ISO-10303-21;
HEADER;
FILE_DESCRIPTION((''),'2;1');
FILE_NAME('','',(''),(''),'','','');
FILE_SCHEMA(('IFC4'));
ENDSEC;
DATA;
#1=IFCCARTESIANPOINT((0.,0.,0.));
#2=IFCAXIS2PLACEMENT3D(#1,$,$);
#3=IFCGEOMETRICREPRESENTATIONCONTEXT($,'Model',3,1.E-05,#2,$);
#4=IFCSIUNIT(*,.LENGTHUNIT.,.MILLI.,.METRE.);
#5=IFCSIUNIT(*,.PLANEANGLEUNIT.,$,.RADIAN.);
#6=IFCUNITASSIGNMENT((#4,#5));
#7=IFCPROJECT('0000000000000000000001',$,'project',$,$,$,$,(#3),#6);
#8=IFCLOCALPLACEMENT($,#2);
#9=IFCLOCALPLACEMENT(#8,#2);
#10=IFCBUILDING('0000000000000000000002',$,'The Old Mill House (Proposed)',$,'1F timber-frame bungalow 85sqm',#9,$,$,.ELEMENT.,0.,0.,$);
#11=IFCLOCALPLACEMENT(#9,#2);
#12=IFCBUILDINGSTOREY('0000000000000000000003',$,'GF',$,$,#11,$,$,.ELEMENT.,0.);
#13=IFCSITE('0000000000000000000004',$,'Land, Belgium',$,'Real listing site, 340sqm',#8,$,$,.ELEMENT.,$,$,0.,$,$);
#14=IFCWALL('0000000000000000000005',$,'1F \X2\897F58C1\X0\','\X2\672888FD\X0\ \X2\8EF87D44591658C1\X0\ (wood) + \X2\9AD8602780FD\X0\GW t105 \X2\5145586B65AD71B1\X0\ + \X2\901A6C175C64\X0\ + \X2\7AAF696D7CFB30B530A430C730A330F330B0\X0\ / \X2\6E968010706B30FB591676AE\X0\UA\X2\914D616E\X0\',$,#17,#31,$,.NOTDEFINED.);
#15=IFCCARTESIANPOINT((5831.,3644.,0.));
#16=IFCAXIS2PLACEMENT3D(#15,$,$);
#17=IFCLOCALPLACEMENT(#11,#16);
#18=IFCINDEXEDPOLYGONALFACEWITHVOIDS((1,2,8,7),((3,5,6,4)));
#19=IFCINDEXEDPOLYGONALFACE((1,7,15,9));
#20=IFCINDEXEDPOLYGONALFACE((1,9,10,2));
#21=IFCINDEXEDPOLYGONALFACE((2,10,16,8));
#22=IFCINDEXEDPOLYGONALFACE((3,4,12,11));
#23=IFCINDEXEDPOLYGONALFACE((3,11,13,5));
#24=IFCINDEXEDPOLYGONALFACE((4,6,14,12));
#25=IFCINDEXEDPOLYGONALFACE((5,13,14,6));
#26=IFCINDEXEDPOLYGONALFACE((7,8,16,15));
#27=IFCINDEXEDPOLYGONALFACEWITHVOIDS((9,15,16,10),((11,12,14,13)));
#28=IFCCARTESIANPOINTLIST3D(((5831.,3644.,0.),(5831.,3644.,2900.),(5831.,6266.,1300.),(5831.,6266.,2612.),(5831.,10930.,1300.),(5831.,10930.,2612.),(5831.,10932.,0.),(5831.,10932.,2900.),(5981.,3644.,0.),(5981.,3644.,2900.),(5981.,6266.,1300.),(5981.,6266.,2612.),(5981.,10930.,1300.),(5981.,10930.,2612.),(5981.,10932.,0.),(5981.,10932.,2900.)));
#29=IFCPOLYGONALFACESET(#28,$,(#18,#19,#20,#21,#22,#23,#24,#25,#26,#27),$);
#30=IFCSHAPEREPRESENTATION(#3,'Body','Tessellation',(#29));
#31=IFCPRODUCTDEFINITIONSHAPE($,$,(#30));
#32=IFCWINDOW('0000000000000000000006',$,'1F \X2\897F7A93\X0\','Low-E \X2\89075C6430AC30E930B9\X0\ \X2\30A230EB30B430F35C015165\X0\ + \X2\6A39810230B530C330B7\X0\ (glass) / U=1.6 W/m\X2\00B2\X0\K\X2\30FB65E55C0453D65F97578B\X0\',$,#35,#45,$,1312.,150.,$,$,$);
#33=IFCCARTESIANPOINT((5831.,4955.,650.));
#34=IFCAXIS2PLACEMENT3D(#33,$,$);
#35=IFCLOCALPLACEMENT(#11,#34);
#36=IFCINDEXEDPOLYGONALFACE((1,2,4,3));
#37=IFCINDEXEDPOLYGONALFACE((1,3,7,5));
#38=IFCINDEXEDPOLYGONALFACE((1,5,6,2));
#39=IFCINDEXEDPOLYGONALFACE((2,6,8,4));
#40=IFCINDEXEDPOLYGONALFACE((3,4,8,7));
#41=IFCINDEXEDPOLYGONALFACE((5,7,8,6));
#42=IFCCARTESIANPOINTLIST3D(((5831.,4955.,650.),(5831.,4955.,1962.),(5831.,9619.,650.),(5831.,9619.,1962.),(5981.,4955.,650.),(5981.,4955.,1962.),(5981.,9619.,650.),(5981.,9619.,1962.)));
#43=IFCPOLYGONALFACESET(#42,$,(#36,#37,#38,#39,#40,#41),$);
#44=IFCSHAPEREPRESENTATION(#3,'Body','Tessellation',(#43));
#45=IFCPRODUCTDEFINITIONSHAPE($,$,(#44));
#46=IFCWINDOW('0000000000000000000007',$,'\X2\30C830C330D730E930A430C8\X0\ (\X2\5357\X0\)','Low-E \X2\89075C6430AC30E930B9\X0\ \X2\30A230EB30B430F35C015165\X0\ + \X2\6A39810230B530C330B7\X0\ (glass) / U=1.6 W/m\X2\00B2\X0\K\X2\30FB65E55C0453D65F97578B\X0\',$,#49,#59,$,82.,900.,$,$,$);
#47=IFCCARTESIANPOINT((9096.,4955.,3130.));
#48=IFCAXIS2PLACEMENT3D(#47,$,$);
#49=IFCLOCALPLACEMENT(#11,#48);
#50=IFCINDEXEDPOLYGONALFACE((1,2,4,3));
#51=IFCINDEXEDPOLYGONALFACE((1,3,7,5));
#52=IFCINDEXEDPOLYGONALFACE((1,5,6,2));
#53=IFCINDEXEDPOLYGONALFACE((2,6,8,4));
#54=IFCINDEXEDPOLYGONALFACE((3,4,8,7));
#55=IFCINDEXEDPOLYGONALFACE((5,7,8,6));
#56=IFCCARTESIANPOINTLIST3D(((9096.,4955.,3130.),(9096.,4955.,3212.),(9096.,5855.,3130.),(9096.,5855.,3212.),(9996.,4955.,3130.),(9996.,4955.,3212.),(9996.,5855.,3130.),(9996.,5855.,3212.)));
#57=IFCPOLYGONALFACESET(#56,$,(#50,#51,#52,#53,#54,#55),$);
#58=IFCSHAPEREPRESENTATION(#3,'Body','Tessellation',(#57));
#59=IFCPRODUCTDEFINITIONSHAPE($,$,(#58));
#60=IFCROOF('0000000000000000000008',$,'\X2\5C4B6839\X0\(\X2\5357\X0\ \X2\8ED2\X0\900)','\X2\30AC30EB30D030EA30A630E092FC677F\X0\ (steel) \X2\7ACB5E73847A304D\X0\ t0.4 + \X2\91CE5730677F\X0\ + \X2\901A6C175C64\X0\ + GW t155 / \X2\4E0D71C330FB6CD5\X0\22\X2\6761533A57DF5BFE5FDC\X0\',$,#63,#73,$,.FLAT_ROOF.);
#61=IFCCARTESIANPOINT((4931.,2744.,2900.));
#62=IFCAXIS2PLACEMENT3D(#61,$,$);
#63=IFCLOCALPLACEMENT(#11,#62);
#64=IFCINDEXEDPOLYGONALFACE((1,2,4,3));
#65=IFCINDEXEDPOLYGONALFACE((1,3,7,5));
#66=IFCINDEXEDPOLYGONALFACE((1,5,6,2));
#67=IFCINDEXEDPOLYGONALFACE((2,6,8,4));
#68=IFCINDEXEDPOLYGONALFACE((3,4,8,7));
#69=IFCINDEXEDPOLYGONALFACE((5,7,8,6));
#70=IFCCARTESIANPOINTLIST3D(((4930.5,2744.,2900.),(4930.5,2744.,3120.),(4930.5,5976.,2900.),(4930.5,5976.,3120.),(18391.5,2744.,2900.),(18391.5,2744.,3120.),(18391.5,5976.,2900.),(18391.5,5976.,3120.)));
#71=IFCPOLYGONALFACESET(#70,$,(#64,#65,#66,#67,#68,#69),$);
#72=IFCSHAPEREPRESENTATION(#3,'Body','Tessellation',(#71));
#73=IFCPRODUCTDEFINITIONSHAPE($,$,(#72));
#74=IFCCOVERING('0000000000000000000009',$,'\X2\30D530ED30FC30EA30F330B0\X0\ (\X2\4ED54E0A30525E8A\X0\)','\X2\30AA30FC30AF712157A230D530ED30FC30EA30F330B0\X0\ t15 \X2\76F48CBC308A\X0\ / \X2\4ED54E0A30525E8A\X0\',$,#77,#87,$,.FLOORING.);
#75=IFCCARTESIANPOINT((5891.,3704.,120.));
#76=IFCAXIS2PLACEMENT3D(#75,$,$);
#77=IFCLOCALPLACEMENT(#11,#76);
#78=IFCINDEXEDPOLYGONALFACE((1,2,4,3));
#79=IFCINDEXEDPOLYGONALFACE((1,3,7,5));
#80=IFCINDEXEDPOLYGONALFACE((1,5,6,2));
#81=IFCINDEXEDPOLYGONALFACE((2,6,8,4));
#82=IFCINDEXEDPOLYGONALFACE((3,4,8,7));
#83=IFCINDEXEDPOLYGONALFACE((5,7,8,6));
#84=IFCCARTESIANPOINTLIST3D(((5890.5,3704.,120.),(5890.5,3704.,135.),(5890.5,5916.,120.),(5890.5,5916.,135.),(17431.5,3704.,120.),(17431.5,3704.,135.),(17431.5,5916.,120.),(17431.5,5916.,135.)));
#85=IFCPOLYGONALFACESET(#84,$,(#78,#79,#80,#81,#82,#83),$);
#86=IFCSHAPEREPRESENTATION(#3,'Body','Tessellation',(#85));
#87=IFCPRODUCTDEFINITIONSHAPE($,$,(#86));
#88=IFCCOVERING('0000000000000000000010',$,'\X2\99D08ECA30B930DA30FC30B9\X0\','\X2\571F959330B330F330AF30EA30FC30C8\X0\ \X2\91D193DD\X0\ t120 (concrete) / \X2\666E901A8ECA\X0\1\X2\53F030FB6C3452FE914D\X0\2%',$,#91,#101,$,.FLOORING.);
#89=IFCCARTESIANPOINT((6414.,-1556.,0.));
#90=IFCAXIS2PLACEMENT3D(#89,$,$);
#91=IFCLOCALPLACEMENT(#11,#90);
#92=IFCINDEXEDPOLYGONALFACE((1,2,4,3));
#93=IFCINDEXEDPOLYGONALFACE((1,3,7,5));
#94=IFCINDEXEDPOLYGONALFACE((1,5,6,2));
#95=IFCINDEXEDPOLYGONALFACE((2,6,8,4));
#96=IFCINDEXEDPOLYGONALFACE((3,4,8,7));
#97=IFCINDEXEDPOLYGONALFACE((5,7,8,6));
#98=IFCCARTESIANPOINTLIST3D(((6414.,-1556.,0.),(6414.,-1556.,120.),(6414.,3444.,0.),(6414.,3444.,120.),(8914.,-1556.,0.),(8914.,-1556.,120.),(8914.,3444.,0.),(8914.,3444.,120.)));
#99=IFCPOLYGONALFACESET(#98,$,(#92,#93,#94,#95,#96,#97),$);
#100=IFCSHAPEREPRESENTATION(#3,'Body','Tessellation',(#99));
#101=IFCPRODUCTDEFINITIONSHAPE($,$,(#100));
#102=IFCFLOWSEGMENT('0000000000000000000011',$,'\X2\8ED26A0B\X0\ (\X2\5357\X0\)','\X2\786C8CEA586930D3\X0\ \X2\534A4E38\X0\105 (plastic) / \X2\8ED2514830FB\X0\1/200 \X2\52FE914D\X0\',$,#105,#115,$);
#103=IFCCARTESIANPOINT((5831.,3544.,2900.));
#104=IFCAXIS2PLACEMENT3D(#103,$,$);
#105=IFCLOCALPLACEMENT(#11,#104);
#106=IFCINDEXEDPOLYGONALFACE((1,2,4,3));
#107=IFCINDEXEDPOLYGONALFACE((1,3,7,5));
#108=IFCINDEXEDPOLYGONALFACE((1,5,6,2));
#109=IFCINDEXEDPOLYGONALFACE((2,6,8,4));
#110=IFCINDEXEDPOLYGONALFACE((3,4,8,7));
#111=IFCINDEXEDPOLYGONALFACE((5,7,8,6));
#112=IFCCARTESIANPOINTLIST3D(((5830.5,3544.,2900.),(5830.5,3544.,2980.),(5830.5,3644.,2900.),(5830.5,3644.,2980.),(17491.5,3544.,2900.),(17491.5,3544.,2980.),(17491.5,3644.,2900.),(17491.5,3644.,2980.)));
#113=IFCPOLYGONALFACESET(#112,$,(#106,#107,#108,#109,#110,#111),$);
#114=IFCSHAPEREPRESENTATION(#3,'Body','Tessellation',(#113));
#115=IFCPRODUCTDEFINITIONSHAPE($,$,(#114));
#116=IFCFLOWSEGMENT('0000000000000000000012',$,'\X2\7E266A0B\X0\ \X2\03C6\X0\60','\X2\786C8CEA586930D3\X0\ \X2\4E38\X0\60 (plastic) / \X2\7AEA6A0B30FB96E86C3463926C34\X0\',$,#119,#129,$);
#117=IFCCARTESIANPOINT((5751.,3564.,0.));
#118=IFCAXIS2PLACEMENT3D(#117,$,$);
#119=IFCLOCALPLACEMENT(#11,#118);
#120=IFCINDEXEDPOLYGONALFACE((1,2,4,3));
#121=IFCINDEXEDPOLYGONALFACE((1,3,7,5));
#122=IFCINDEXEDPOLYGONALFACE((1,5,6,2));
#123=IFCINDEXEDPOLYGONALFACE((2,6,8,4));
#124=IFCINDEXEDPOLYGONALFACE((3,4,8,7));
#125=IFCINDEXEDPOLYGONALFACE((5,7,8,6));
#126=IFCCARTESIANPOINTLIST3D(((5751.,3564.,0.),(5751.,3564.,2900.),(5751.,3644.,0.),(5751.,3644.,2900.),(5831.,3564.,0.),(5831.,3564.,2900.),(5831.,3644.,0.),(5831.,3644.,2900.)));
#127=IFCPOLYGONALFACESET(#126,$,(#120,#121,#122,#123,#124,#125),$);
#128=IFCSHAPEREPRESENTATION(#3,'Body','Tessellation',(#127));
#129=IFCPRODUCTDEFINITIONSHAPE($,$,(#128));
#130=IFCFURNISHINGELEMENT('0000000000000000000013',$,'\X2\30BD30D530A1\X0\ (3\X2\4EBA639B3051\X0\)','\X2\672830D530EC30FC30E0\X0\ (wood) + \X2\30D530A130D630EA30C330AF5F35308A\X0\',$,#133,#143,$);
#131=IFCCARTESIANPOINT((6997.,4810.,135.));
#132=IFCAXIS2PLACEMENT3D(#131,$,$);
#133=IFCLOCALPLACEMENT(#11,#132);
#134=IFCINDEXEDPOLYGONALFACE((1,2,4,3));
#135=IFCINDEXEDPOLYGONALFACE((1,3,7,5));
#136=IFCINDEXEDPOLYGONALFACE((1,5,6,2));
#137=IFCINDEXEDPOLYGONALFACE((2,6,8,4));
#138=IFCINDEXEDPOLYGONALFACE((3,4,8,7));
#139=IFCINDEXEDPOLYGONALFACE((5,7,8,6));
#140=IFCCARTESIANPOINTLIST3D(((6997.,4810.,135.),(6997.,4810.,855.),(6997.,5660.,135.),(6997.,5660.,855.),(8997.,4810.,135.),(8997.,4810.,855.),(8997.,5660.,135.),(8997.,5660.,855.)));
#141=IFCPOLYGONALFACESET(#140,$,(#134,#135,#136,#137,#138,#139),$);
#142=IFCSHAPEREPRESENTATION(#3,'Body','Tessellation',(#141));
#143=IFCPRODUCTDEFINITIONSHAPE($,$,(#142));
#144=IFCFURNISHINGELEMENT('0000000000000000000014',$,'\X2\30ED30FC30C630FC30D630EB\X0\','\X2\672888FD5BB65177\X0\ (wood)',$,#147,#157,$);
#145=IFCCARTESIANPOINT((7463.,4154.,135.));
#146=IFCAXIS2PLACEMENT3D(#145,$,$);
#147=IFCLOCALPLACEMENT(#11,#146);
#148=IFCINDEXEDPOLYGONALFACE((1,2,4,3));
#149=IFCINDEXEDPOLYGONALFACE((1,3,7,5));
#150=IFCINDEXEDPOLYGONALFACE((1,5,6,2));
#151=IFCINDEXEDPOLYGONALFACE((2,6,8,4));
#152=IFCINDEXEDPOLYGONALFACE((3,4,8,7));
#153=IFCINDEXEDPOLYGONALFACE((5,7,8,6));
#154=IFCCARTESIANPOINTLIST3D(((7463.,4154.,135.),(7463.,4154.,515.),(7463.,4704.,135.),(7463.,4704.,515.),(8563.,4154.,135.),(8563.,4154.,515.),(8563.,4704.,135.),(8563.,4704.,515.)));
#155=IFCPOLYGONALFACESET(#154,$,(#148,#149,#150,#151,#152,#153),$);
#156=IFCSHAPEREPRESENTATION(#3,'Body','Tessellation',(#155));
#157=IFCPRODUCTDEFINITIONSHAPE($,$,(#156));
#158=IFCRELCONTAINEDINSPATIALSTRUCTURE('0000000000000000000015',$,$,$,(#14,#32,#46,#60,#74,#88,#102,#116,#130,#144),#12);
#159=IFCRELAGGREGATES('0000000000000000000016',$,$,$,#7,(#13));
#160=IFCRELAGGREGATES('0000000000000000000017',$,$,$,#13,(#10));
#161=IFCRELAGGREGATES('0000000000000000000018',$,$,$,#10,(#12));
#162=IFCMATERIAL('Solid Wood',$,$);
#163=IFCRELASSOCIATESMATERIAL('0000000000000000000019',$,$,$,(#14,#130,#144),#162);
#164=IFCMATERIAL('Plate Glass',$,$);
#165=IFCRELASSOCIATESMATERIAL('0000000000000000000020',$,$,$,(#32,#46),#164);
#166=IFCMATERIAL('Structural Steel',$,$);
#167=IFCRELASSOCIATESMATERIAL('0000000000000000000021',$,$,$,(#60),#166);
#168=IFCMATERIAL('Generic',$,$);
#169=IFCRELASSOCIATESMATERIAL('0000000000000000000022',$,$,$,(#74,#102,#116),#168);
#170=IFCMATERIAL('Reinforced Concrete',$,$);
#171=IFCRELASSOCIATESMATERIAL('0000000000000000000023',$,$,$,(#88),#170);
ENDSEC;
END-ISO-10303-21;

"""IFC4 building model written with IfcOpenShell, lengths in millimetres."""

from ifc_helpers import new_model, si_unit, frame, frame_2d, origin, place, context, project, spatial, rectangle, extrude, material, element, fill, save


model = new_model("IFC4")

# Units and contexts
model_context = context("Model", 3, precision=1e-05, world=origin())
ifc_project = project(units=[si_unit("LENGTHUNIT", "METRE", prefix="MILLI"), si_unit("PLANEANGLEUNIT", "RADIAN")], contexts=[model_context])

# Site, building, storey
site_placement = place(None, origin())
site = spatial("IfcSite", under=ifc_project, at=site_placement, Name="Land, Belgium", ObjectType="Real listing site, 340sqm", CompositionType="ELEMENT", RefElevation=0.0)
building_placement = place(site_placement, origin())
building = spatial("IfcBuilding", under=site, at=building_placement, Name="The Old Mill House (Proposed)", ObjectType="1F timber-frame bungalow 85sqm", CompositionType="ELEMENT", ElevationOfRefHeight=0.0, ElevationOfTerrain=0.0)
storey_placement = place(building_placement, origin())
storey = spatial("IfcBuildingStorey", under=building, at=storey_placement, Name="GF", CompositionType="ELEMENT", Elevation=0.0)

# Shared definitions
ifc_material_1 = material(Name="Solid Wood")

# Shared definitions
ifc_material_2 = material(Name="Reinforced Concrete")

# Shared definitions
ifc_material_3 = material(Name="Plate Glass")

# Wall, opening, window
wall_1_placement = place(storey_placement, frame((5831.0, 3644.0, 0.0)))
wall_1 = element("IfcWall", 1, at=wall_1_placement, inside=storey, material=ifc_material_1, Name="1F 西壁", Description="木製 軸組外壁 (wood) + 高性能GW t105 充填断熱 + 通気層 + 窯業系サイディング / 準耐火・外皮UA配慮", PredefinedType="NOTDEFINED", context=model_context, shape_type="SweptSolid", body=[
    extrude(rectangle(XDim=150.0, YDim=7288.0, at=frame_2d((75.0, 3644.0))), frame((5831.0, 3644.0, 0.0)), (0.0, 0.0, 1.0), 2900.0),
])
opening_1_placement = place(storey_placement, frame((5831.0, 4955.0, 650.0)))
opening_1 = element("IfcOpeningElement", 2, at=opening_1_placement, cuts=wall_1, PredefinedType="NOTDEFINED", context=model_context, shape_type="SweptSolid", body=[
    extrude(rectangle(XDim=150.0, YDim=4664.0, at=frame_2d((75.0, 2332.0))), frame((5831.0, 4955.0, 650.0)), (0.0, 0.0, 1.0), 1312.0),
])
window_1_placement = place(storey_placement, frame((5831.0, 4955.0, 650.0)))
window_1 = element("IfcWindow", 3, at=window_1_placement, inside=storey, material=ifc_material_3, Name="1F 西窓", Description="Low-E 複層ガラス アルゴン封入 + 樹脂サッシ (glass) / U=1.6 W/m²K・日射取得型", OverallHeight=1312.0, OverallWidth=150.0, context=model_context, shape_type="SweptSolid", body=[
    extrude(rectangle(XDim=150.0, YDim=4664.0, at=frame_2d((75.0, 2332.0))), frame((5831.0, 4955.0, 650.0)), (0.0, 0.0, 1.0), 1312.0),
])
fill(opening_1, window_1)

# Window
window_2_placement = place(storey_placement, frame((9096.0, 4955.0, 3130.0)))
element("IfcWindow", 4, at=window_2_placement, inside=storey, material=ifc_material_3, Name="トップライト (南)", Description="Low-E 複層ガラス アルゴン封入 + 樹脂サッシ (glass) / U=1.6 W/m²K・日射取得型", OverallHeight=82.0, OverallWidth=900.0, context=model_context, shape_type="SweptSolid", body=[
    extrude(rectangle(XDim=900.0, YDim=900.0, at=frame_2d((450.0, 450.0))), frame((9096.0, 4955.0, 3130.0)), (0.0, 0.0, 1.0), 82.0),
])

# Roof
ifc_material_4 = material(Name="Structural Steel")
roof_1_placement = place(storey_placement, frame((4931.0, 2744.0, 2900.0)))
element("IfcRoof", 5, at=roof_1_placement, inside=storey, material=ifc_material_4, Name="屋根(南 軒900)", Description="ガルバリウム鋼板 (steel) 立平葺き t0.4 + 野地板 + 通気層 + GW t155 / 不燃・法22条区域対応", PredefinedType="FLAT_ROOF", context=model_context, shape_type="SweptSolid", body=[
    extrude(rectangle(XDim=13461.0, YDim=3232.0, at=frame_2d((6730.0, 1616.0))), frame((4931.0, 2744.0, 2900.0)), (0.0, 0.0, 1.0), 220.0),
])

# Coverings
ifc_material_5 = material(Name="Generic")
covering_1_placement = place(storey_placement, frame((5891.0, 3704.0, 120.0)))
element("IfcCovering", 6, at=covering_1_placement, inside=storey, material=ifc_material_5, Name="フローリング (仕上げ床)", Description="オーク無垢フローリング t15 直貼り / 仕上げ床", PredefinedType="FLOORING", context=model_context, shape_type="SweptSolid", body=[
    extrude(rectangle(XDim=11541.0, YDim=2212.0, at=frame_2d((5770.0, 1106.0))), frame((5891.0, 3704.0, 120.0)), (0.0, 0.0, 1.0), 15.0),
])
covering_2_placement = place(storey_placement, frame((6414.0, -1556.0, 0.0)))
element("IfcCovering", 7, at=covering_2_placement, inside=storey, material=ifc_material_2, Name="駐車スペース", Description="土間コンクリート 金鏝 t120 (concrete) / 普通車1台・水勾配2%", PredefinedType="FLOORING", context=model_context, shape_type="SweptSolid", body=[
    extrude(rectangle(XDim=2500.0, YDim=5000.0, at=frame_2d((1250.0, 2500.0))), frame((6414.0, -1556.0, 0.0)), (0.0, 0.0, 1.0), 120.0),
])

# Flow segments
flow_segment_1_placement = place(storey_placement, frame((5831.0, 3544.0, 2900.0)))
element("IfcFlowSegment", 8, at=flow_segment_1_placement, inside=storey, material=ifc_material_5, Name="軒樋 (南)", Description="硬質塩ビ 半丸105 (plastic) / 軒先・1/200 勾配", context=model_context, shape_type="SweptSolid", body=[
    extrude(rectangle(XDim=11661.0, YDim=100.0, at=frame_2d((5830.0, 50.0))), frame((5831.0, 3544.0, 2900.0)), (0.0, 0.0, 1.0), 80.0),
])
flow_segment_2_placement = place(storey_placement, frame((5751.0, 3564.0, 0.0)))
element("IfcFlowSegment", 9, at=flow_segment_2_placement, inside=storey, material=ifc_material_5, Name="縦樋 φ60", Description="硬質塩ビ 丸60 (plastic) / 竪樋・雨水排水", context=model_context, shape_type="SweptSolid", body=[
    extrude(rectangle(XDim=80.0, YDim=80.0, at=frame_2d((40.0, 40.0))), frame((5751.0, 3564.0, 0.0)), (0.0, 0.0, 1.0), 2900.0),
])

# Furnishing elements
furnishing_1_placement = place(storey_placement, frame((6997.0, 4810.0, 135.0)))
element("IfcFurnishingElement", 10, at=furnishing_1_placement, inside=storey, material=ifc_material_1, Name="ソファ (3人掛け)", Description="木フレーム (wood) + ファブリック張り", context=model_context, shape_type="SweptSolid", body=[
    extrude(rectangle(XDim=2000.0, YDim=850.0, at=frame_2d((1000.0, 425.0))), frame((6997.0, 4810.0, 135.0)), (0.0, 0.0, 1.0), 720.0),
])
furnishing_2_placement = place(storey_placement, frame((7463.0, 4154.0, 135.0)))
element("IfcFurnishingElement", 11, at=furnishing_2_placement, inside=storey, material=ifc_material_1, Name="ローテーブル", Description="木製家具 (wood)", context=model_context, shape_type="SweptSolid", body=[
    extrude(rectangle(XDim=1100.0, YDim=550.0, at=frame_2d((550.0, 275.0))), frame((7463.0, 4154.0, 135.0)), (0.0, 0.0, 1.0), 380.0),
])

save(model, "model.ifc")
